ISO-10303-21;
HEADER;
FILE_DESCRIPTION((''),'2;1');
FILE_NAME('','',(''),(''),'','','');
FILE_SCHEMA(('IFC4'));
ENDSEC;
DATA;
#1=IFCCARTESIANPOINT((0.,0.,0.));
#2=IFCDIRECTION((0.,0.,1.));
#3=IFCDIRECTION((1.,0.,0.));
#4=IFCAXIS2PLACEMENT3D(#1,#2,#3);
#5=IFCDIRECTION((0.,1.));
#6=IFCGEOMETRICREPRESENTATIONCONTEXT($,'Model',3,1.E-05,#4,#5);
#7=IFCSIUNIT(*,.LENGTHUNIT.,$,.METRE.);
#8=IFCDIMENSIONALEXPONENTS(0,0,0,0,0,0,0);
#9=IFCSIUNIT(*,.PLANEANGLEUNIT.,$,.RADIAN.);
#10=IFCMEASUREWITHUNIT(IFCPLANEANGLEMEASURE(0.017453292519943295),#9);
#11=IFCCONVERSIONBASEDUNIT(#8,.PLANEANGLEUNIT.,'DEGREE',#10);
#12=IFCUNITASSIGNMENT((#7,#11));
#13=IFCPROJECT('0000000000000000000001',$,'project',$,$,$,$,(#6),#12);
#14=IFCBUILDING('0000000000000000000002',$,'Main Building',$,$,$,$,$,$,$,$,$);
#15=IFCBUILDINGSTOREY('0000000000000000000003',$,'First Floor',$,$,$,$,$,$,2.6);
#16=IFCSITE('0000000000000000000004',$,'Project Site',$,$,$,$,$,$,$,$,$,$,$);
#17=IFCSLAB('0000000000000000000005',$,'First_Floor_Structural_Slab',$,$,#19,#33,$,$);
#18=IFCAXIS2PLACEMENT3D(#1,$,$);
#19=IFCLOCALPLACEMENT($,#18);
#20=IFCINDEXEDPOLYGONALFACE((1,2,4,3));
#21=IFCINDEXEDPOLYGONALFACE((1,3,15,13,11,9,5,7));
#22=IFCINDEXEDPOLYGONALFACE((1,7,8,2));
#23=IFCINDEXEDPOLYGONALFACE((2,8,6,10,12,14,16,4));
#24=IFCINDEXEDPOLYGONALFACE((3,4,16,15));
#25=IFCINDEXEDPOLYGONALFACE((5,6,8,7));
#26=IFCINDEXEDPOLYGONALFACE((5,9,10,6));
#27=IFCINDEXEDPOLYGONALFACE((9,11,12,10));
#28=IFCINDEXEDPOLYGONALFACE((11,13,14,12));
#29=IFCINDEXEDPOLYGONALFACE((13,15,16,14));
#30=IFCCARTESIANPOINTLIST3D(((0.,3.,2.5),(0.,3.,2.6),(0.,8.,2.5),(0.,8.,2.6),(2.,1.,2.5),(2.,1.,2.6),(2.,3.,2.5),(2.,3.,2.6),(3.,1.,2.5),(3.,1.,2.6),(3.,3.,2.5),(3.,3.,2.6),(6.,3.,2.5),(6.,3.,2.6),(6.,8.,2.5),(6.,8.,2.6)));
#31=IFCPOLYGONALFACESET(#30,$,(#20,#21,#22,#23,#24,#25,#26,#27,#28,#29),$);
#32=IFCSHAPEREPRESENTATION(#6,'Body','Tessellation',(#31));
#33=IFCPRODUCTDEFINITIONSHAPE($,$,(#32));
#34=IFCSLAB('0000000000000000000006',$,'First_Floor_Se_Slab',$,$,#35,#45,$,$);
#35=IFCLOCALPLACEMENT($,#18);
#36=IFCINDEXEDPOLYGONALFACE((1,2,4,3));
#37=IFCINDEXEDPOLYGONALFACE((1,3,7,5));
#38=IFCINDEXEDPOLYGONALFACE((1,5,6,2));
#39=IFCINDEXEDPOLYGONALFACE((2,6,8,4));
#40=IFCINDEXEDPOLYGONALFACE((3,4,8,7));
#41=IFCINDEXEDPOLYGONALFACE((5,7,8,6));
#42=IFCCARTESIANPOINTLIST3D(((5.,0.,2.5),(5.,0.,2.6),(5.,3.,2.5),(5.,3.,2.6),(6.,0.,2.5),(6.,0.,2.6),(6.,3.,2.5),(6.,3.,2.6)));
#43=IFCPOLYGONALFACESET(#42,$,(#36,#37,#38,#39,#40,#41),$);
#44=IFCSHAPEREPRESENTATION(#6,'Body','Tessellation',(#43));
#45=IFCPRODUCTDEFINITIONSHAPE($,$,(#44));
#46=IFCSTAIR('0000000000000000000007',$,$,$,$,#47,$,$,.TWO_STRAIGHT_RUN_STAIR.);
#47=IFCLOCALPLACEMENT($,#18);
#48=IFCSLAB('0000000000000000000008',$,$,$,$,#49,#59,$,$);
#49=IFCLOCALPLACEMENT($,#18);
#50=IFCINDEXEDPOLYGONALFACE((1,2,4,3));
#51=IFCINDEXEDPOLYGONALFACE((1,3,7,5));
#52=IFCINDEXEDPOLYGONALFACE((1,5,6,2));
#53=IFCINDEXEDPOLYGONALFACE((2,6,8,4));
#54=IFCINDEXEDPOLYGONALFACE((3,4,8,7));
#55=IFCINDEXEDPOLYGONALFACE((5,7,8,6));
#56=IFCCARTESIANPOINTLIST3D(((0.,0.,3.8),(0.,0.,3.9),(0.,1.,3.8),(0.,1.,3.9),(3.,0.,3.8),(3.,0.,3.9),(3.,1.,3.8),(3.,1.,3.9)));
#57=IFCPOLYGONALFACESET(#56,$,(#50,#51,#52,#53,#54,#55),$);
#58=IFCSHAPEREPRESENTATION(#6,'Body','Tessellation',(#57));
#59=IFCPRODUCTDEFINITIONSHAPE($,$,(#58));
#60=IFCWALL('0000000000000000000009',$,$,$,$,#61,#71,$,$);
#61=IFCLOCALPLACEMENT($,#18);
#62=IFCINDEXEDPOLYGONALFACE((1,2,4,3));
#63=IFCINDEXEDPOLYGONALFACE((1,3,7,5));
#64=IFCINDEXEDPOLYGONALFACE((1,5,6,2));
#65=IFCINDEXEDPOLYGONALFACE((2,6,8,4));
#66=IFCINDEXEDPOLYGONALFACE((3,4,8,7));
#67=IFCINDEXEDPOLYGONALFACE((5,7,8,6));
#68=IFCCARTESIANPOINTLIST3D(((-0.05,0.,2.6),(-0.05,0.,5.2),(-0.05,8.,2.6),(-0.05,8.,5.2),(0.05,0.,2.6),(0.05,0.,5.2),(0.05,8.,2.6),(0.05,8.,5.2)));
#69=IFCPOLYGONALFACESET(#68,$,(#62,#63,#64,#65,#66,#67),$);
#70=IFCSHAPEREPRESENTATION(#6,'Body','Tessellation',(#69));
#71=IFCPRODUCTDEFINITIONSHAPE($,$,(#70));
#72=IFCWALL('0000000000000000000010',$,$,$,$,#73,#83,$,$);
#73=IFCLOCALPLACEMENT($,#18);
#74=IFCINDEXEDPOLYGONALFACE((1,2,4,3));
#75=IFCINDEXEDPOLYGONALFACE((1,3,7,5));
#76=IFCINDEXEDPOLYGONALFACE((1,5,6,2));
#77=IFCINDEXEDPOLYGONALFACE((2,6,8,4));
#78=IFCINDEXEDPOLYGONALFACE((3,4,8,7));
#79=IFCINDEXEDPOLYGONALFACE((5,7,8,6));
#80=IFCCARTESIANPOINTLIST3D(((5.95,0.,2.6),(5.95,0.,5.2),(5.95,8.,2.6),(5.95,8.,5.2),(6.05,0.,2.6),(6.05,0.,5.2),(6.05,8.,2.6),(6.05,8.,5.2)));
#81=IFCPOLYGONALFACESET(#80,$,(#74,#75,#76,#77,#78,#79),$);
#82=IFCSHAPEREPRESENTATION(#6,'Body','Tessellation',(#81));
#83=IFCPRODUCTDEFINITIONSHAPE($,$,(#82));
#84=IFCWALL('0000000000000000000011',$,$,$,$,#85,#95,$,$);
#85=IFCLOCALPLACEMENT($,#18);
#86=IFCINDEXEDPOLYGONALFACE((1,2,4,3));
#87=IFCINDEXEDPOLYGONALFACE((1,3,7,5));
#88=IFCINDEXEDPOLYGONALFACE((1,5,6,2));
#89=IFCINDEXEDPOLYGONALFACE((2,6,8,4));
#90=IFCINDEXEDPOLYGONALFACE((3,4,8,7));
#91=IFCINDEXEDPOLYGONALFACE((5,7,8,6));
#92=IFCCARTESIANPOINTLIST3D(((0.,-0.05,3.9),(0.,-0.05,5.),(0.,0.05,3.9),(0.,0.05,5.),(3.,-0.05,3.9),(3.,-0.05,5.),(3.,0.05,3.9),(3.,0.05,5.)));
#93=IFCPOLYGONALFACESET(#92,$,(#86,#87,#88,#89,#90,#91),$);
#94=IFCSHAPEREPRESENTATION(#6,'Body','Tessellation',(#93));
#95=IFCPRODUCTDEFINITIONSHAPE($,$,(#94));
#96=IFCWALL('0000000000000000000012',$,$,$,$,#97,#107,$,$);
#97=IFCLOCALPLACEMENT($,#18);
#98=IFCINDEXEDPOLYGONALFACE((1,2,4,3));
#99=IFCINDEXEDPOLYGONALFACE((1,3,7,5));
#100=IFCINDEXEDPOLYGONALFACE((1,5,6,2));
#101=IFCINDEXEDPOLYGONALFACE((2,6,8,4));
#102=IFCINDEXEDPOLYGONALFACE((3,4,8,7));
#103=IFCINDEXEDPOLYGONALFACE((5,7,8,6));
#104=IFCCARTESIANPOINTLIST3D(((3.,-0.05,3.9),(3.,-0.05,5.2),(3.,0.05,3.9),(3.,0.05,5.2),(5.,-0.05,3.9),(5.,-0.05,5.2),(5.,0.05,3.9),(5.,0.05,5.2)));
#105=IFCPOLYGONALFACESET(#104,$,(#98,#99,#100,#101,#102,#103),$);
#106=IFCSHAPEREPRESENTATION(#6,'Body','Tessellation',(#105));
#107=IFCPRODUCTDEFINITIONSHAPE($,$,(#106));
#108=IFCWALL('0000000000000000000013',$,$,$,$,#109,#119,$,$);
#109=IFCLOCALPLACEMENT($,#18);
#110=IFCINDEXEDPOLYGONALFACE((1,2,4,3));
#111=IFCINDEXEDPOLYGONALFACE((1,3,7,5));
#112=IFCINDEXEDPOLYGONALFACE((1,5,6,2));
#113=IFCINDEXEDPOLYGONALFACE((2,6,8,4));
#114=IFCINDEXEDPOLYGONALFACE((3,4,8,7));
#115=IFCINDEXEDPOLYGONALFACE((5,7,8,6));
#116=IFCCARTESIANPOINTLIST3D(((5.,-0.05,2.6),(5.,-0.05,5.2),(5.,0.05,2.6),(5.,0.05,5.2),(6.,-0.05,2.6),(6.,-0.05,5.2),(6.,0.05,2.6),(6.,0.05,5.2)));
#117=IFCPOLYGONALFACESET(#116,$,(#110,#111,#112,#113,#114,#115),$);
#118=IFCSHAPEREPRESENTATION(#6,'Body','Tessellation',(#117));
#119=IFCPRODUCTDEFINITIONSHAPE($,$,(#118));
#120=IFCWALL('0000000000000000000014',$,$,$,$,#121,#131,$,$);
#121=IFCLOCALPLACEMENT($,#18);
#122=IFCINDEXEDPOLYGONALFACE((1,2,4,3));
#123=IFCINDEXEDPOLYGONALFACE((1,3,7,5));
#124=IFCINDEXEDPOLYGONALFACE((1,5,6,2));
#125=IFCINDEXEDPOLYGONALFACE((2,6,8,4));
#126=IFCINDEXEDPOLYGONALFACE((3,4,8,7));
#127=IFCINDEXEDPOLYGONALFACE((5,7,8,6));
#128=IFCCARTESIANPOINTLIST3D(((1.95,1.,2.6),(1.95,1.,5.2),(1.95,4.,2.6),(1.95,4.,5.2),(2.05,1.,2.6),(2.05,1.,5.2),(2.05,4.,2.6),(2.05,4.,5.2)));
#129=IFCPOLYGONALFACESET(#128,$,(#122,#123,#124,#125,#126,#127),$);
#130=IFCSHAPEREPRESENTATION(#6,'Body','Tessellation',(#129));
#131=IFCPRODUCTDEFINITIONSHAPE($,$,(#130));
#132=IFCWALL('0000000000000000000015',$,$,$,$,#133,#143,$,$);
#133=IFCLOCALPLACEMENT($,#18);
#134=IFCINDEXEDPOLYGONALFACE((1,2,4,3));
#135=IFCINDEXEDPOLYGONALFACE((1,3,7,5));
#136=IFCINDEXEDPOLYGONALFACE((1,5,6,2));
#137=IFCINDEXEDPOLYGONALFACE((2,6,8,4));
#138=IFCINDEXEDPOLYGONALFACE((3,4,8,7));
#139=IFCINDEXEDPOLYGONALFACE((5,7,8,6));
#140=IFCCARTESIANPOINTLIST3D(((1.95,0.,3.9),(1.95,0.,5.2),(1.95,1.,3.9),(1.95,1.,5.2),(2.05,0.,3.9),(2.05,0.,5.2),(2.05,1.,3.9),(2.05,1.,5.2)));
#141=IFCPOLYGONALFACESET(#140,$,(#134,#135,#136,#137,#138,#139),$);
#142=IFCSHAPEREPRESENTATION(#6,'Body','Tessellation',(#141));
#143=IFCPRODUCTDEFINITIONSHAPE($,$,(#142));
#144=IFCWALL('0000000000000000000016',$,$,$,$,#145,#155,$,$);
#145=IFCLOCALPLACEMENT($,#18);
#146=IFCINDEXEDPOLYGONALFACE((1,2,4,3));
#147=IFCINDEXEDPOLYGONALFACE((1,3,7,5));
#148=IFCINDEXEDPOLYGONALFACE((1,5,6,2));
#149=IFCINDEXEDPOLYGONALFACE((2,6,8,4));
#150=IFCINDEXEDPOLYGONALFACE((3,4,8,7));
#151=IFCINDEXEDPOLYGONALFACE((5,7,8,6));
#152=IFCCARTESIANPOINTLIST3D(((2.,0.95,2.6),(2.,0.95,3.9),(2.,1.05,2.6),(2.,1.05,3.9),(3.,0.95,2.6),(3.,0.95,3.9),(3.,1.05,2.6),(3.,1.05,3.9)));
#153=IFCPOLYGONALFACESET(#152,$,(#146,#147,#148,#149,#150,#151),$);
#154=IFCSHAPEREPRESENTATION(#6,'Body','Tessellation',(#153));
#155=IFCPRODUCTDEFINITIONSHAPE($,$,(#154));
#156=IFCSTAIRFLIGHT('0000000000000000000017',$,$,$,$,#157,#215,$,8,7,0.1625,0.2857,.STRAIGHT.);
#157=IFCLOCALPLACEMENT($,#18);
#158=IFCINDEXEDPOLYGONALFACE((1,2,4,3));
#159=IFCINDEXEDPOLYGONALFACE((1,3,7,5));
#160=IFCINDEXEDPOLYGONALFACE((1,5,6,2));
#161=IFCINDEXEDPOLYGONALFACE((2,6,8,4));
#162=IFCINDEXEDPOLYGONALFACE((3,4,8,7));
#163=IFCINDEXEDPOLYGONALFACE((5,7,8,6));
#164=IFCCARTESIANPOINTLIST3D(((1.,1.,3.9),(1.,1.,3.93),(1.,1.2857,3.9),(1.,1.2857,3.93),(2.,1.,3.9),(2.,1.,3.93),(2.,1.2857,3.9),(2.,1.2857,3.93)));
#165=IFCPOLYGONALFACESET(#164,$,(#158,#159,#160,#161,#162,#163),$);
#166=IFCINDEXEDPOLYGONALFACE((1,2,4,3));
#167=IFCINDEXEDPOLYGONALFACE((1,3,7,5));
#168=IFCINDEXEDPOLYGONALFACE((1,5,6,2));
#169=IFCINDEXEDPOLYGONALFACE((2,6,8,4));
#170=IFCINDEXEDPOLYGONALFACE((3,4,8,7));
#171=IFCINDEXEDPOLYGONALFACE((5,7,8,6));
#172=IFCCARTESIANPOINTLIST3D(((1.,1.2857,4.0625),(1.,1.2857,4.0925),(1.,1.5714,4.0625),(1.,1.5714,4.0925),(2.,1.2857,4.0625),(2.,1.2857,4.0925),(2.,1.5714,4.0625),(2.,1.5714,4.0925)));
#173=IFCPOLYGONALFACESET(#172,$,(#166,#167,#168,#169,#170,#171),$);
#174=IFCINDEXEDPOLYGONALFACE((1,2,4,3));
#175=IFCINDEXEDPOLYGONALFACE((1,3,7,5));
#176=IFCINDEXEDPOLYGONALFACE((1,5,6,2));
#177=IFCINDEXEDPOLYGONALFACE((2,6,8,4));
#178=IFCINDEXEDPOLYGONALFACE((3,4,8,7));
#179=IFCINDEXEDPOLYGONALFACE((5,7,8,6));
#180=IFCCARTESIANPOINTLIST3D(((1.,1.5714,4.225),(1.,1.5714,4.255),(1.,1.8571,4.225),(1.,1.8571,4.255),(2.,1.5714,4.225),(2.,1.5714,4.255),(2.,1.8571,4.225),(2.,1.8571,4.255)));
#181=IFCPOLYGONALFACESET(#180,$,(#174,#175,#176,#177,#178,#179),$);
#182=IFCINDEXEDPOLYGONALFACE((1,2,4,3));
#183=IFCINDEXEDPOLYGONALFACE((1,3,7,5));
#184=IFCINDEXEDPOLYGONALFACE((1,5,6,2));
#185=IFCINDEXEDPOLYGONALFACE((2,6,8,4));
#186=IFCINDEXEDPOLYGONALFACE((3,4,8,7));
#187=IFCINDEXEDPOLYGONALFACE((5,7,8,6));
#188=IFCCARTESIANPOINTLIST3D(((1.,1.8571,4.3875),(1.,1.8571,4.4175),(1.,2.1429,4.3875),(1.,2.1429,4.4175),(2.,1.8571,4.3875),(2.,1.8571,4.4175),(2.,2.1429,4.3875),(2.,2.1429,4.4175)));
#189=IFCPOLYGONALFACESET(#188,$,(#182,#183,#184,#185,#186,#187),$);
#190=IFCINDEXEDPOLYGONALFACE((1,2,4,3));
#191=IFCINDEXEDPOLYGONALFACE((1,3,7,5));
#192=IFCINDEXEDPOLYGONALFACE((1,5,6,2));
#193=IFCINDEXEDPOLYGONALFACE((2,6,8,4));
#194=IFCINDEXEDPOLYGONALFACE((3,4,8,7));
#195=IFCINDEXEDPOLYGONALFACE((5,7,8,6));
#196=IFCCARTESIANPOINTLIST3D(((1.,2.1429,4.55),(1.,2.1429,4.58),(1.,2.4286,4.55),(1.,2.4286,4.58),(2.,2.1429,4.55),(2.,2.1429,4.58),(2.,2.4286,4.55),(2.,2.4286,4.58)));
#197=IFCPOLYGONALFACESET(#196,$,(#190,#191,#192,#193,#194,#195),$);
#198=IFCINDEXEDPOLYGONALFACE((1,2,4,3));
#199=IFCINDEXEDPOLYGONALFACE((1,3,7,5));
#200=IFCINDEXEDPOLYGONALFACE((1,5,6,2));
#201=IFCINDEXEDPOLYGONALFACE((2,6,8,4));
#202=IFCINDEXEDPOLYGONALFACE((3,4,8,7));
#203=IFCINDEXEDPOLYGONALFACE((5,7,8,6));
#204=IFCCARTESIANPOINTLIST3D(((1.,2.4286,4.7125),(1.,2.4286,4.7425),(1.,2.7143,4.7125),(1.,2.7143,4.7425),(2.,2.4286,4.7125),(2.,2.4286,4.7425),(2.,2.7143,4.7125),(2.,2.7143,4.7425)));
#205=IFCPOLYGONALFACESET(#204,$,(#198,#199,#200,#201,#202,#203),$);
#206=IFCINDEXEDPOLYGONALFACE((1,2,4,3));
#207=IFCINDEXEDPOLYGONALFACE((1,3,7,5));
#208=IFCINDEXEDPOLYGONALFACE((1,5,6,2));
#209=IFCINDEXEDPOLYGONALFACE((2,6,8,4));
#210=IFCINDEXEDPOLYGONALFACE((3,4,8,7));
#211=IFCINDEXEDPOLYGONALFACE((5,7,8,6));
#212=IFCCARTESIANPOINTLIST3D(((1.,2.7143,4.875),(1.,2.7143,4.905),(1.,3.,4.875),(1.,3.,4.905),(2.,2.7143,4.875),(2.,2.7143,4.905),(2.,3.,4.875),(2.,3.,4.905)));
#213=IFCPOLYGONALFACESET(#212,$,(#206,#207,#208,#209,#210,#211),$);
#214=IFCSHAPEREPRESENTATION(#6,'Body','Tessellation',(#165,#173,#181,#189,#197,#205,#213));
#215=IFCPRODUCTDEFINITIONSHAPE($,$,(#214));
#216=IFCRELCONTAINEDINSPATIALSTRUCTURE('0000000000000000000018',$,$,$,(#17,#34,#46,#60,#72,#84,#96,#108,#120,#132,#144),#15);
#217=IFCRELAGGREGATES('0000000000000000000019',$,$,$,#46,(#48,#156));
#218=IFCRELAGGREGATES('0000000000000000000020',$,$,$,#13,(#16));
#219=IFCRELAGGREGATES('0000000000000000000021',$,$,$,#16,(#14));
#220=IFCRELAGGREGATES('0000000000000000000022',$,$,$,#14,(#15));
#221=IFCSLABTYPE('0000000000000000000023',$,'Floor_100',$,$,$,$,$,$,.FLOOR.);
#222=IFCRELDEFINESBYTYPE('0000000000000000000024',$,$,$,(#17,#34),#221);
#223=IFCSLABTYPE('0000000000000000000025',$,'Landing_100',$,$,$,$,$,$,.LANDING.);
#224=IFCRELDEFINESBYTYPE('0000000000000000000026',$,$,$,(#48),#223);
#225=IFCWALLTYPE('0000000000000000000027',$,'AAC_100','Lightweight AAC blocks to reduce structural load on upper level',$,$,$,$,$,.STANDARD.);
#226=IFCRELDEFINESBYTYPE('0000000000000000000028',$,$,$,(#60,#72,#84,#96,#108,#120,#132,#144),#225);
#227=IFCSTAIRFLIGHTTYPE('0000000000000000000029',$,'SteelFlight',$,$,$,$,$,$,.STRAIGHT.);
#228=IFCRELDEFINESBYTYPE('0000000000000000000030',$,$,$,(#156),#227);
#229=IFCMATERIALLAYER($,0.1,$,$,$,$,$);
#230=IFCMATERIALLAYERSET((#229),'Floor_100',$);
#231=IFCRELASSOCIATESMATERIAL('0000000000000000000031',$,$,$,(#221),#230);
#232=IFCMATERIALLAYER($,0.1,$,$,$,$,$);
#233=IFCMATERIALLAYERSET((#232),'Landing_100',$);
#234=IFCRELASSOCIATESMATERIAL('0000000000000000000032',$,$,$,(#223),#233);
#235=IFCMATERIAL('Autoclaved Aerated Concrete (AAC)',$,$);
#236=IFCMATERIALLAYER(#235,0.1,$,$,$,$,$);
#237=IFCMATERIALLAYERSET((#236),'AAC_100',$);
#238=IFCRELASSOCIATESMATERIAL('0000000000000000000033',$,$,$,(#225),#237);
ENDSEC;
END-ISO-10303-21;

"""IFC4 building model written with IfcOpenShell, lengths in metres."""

from ifc_helpers import new_model, entity, si_unit, converted_unit, direction, frame, frame_2d, origin, origin_with_axes, place, context, project, spatial, polyline, rectangle, outline, extrude, material, layer, layer_set, type_object, element, aggregate, save


model = new_model("IFC4")

# Units and contexts
model_context = context("Model", 3, precision=1e-05, world=origin_with_axes(), true_north=direction((0.0, 1.0)))
ifc_project = project(units=[si_unit("LENGTHUNIT", "METRE"), converted_unit("PLANEANGLEUNIT", "DEGREE", entity("IfcPlaneAngleMeasure", 0.017453292519943295), si_unit("PLANEANGLEUNIT", "RADIAN"), dimensions=[0, 0, 0, 0, 0, 0, 0])], contexts=[model_context])

# Site, building, storey
site = spatial("IfcSite", under=ifc_project, Name="Project Site")
building = spatial("IfcBuilding", under=site, Name="Main Building")
storey = spatial("IfcBuildingStorey", under=building, Name="First Floor", Elevation=2.6)

# Slabs
ifc_layer_1 = layer(None, 0.1)
ifc_layer_set_1 = layer_set([ifc_layer_1], Name="Floor_100")
slab_type_1 = type_object("IfcSlabType", Name="Floor_100", PredefinedType="FLOOR", material=ifc_layer_set_1)
slab_1_placement = place(None, frame((0.0, 0.0, 2.5), z_axis=(0.0, 0.0, 1.0), x_axis=(1.0, 0.0, 0.0)))
element("IfcSlab", 1, at=slab_1_placement, inside=storey, type_object=slab_type_1, Name="First_Floor_Structural_Slab", context=model_context, shape_type="SweptSolid", body=[
    extrude(outline(polyline([(0.0, 3.0), (2.0, 3.0), (2.0, 1.0), (3.0, 1.0), (3.0, 3.0), (6.0, 3.0), (6.0, 8.0), (0.0, 8.0), (0.0, 3.0)])), origin(), (0.0, 0.0, 1.0), 0.1),
])
slab_2_placement = place(None, frame((0.0, 0.0, 2.5), z_axis=(0.0, 0.0, 1.0), x_axis=(1.0, 0.0, 0.0)))
element("IfcSlab", 2, at=slab_2_placement, inside=storey, type_object=slab_type_1, Name="First_Floor_Se_Slab", context=model_context, shape_type="SweptSolid", body=[
    extrude(outline(polyline([(5.0, 0.0), (6.0, 0.0), (6.0, 3.0), (5.0, 3.0), (5.0, 0.0)])), origin(), (0.0, 0.0, 1.0), 0.1),
])

# Stair, slab
stair_placement = place(None, origin_with_axes())
stair = element("IfcStair", 3, at=stair_placement, inside=storey, PredefinedType="TWO_STRAIGHT_RUN_STAIR")
ifc_layer_2 = layer(None, 0.1)
ifc_layer_set_2 = layer_set([ifc_layer_2], Name="Landing_100")
slab_type_2 = type_object("IfcSlabType", Name="Landing_100", PredefinedType="LANDING", material=ifc_layer_set_2)
slab_3_placement = place(stair_placement, frame((0.0, 0.0, 3.8), z_axis=(0.0, 0.0, 1.0), x_axis=(1.0, 0.0, 0.0)))
slab_3 = element("IfcSlab", 4, at=slab_3_placement, type_object=slab_type_2, context=model_context, shape_type="SweptSolid", body=[
    extrude(outline(polyline([(0.0, 0.0), (3.0, 0.0), (3.0, 1.0), (0.0, 1.0), (0.0, 0.0)])), origin(), (0.0, 0.0, 1.0), 0.1),
])

# Walls
ifc_material_1 = material(Name="Autoclaved Aerated Concrete (AAC)")
ifc_layer_3 = layer(ifc_material_1, 0.1)
ifc_layer_set_3 = layer_set([ifc_layer_3], Name="AAC_100")
wall_type = type_object("IfcWallType", Name="AAC_100", Description="Lightweight AAC blocks to reduce structural load on upper level", PredefinedType="STANDARD", material=ifc_layer_set_3)
for number, where, z_axis, x_axis in (
    (5, (0.0, 0.0, 2.6), (0.0, 0.0, 1.0), (0.0, 1.0, 0.0)),
    (6, (6.0, 0.0, 2.6), (0.0, 0.0, 1.0), (0.0, 1.0, 0.0)),
):
    element("IfcWall", number, at=place(None, frame(where, z_axis=z_axis, x_axis=x_axis)), inside=storey, type_object=wall_type, context=model_context, shape_type="SweptSolid", body=[
        extrude(rectangle(XDim=8.0, YDim=0.1, at=frame_2d((4.0, 0.0))), origin(), (0.0, 0.0, 1.0), 2.6),
    ])
wall_1_placement = place(None, frame((0.0, 0.0, 3.9), z_axis=(0.0, 0.0, 1.0), x_axis=(1.0, 0.0, 0.0)))
element("IfcWall", 7, at=wall_1_placement, inside=storey, type_object=wall_type, context=model_context, shape_type="SweptSolid", body=[
    extrude(rectangle(XDim=3.0, YDim=0.1, at=frame_2d((1.5, 0.0))), origin(), (0.0, 0.0, 1.0), 1.1),
])
wall_2_placement = place(None, frame((3.0, 0.0, 3.9), z_axis=(0.0, 0.0, 1.0), x_axis=(1.0, 0.0, 0.0)))
element("IfcWall", 8, at=wall_2_placement, inside=storey, type_object=wall_type, context=model_context, shape_type="SweptSolid", body=[
    extrude(rectangle(XDim=2.0, YDim=0.1, at=frame_2d((1.0, 0.0))), origin(), (0.0, 0.0, 1.0), 1.3),
])
wall_3_placement = place(None, frame((5.0, 0.0, 2.6), z_axis=(0.0, 0.0, 1.0), x_axis=(1.0, 0.0, 0.0)))
element("IfcWall", 9, at=wall_3_placement, inside=storey, type_object=wall_type, context=model_context, shape_type="SweptSolid", body=[
    extrude(rectangle(XDim=1.0, YDim=0.1, at=frame_2d((0.5, 0.0))), origin(), (0.0, 0.0, 1.0), 2.6),
])
wall_4_placement = place(None, frame((2.0, 1.0, 2.6), z_axis=(0.0, 0.0, 1.0), x_axis=(0.0, 1.0, 0.0)))
element("IfcWall", 10, at=wall_4_placement, inside=storey, type_object=wall_type, context=model_context, shape_type="SweptSolid", body=[
    extrude(rectangle(XDim=3.0, YDim=0.1, at=frame_2d((1.5, 0.0))), origin(), (0.0, 0.0, 1.0), 2.6),
])
for number, where, z_axis, x_axis in (
    (11, (2.0, 0.0, 3.9), (0.0, 0.0, 1.0), (0.0, 1.0, 0.0)),
    (12, (2.0, 1.0, 2.6), (0.0, 0.0, 1.0), (1.0, 0.0, 0.0)),
):
    element("IfcWall", number, at=place(None, frame(where, z_axis=z_axis, x_axis=x_axis)), inside=storey, type_object=wall_type, context=model_context, shape_type="SweptSolid", body=[
        extrude(rectangle(XDim=1.0, YDim=0.1, at=frame_2d((0.5, 0.0))), origin(), (0.0, 0.0, 1.0), 1.3),
    ])

# Stair flight
stair_flight_type = type_object("IfcStairFlightType", Name="SteelFlight", PredefinedType="STRAIGHT")
stair_flight_placement = place(stair_placement, frame((1.5, 1.0, 3.9), z_axis=(0.0, 0.0, 1.0), x_axis=(0.0, 1.0, 0.0)))
stair_flight = element("IfcStairFlight", 13, at=stair_flight_placement, type_object=stair_flight_type, NumberOfRisers=8, NumberOfTreads=7, PredefinedType="STRAIGHT", RiserHeight=0.1625, TreadLength=0.2857, context=model_context, shape_type="SweptSolid", body=[
    extrude(rectangle(XDim=0.2857, YDim=1.0, at=frame_2d((0.1429, 0.0))), origin(), (0.0, 0.0, 1.0), 0.03),
    extrude(rectangle(XDim=0.2857, YDim=1.0, at=frame_2d((0.1429, 0.0))), frame((0.2857, 0.0, 0.1625)), (0.0, 0.0, 1.0), 0.03),
    extrude(rectangle(XDim=0.2857, YDim=1.0, at=frame_2d((0.1429, 0.0))), frame((0.5714, 0.0, 0.325)), (0.0, 0.0, 1.0), 0.03),
    extrude(rectangle(XDim=0.2857, YDim=1.0, at=frame_2d((0.1429, 0.0))), frame((0.8571, 0.0, 0.4875)), (0.0, 0.0, 1.0), 0.03),
    extrude(rectangle(XDim=0.2857, YDim=1.0, at=frame_2d((0.1429, 0.0))), frame((1.1429, 0.0, 0.65)), (0.0, 0.0, 1.0), 0.03),
    extrude(rectangle(XDim=0.2857, YDim=1.0, at=frame_2d((0.1429, 0.0))), frame((1.4286, 0.0, 0.8125)), (0.0, 0.0, 1.0), 0.03),
    extrude(rectangle(XDim=0.2857, YDim=1.0, at=frame_2d((0.1429, 0.0))), frame((1.7143, 0.0, 0.975)), (0.0, 0.0, 1.0), 0.03),
])
aggregate(stair, [slab_3, stair_flight])

save(model, "model.ifc")
